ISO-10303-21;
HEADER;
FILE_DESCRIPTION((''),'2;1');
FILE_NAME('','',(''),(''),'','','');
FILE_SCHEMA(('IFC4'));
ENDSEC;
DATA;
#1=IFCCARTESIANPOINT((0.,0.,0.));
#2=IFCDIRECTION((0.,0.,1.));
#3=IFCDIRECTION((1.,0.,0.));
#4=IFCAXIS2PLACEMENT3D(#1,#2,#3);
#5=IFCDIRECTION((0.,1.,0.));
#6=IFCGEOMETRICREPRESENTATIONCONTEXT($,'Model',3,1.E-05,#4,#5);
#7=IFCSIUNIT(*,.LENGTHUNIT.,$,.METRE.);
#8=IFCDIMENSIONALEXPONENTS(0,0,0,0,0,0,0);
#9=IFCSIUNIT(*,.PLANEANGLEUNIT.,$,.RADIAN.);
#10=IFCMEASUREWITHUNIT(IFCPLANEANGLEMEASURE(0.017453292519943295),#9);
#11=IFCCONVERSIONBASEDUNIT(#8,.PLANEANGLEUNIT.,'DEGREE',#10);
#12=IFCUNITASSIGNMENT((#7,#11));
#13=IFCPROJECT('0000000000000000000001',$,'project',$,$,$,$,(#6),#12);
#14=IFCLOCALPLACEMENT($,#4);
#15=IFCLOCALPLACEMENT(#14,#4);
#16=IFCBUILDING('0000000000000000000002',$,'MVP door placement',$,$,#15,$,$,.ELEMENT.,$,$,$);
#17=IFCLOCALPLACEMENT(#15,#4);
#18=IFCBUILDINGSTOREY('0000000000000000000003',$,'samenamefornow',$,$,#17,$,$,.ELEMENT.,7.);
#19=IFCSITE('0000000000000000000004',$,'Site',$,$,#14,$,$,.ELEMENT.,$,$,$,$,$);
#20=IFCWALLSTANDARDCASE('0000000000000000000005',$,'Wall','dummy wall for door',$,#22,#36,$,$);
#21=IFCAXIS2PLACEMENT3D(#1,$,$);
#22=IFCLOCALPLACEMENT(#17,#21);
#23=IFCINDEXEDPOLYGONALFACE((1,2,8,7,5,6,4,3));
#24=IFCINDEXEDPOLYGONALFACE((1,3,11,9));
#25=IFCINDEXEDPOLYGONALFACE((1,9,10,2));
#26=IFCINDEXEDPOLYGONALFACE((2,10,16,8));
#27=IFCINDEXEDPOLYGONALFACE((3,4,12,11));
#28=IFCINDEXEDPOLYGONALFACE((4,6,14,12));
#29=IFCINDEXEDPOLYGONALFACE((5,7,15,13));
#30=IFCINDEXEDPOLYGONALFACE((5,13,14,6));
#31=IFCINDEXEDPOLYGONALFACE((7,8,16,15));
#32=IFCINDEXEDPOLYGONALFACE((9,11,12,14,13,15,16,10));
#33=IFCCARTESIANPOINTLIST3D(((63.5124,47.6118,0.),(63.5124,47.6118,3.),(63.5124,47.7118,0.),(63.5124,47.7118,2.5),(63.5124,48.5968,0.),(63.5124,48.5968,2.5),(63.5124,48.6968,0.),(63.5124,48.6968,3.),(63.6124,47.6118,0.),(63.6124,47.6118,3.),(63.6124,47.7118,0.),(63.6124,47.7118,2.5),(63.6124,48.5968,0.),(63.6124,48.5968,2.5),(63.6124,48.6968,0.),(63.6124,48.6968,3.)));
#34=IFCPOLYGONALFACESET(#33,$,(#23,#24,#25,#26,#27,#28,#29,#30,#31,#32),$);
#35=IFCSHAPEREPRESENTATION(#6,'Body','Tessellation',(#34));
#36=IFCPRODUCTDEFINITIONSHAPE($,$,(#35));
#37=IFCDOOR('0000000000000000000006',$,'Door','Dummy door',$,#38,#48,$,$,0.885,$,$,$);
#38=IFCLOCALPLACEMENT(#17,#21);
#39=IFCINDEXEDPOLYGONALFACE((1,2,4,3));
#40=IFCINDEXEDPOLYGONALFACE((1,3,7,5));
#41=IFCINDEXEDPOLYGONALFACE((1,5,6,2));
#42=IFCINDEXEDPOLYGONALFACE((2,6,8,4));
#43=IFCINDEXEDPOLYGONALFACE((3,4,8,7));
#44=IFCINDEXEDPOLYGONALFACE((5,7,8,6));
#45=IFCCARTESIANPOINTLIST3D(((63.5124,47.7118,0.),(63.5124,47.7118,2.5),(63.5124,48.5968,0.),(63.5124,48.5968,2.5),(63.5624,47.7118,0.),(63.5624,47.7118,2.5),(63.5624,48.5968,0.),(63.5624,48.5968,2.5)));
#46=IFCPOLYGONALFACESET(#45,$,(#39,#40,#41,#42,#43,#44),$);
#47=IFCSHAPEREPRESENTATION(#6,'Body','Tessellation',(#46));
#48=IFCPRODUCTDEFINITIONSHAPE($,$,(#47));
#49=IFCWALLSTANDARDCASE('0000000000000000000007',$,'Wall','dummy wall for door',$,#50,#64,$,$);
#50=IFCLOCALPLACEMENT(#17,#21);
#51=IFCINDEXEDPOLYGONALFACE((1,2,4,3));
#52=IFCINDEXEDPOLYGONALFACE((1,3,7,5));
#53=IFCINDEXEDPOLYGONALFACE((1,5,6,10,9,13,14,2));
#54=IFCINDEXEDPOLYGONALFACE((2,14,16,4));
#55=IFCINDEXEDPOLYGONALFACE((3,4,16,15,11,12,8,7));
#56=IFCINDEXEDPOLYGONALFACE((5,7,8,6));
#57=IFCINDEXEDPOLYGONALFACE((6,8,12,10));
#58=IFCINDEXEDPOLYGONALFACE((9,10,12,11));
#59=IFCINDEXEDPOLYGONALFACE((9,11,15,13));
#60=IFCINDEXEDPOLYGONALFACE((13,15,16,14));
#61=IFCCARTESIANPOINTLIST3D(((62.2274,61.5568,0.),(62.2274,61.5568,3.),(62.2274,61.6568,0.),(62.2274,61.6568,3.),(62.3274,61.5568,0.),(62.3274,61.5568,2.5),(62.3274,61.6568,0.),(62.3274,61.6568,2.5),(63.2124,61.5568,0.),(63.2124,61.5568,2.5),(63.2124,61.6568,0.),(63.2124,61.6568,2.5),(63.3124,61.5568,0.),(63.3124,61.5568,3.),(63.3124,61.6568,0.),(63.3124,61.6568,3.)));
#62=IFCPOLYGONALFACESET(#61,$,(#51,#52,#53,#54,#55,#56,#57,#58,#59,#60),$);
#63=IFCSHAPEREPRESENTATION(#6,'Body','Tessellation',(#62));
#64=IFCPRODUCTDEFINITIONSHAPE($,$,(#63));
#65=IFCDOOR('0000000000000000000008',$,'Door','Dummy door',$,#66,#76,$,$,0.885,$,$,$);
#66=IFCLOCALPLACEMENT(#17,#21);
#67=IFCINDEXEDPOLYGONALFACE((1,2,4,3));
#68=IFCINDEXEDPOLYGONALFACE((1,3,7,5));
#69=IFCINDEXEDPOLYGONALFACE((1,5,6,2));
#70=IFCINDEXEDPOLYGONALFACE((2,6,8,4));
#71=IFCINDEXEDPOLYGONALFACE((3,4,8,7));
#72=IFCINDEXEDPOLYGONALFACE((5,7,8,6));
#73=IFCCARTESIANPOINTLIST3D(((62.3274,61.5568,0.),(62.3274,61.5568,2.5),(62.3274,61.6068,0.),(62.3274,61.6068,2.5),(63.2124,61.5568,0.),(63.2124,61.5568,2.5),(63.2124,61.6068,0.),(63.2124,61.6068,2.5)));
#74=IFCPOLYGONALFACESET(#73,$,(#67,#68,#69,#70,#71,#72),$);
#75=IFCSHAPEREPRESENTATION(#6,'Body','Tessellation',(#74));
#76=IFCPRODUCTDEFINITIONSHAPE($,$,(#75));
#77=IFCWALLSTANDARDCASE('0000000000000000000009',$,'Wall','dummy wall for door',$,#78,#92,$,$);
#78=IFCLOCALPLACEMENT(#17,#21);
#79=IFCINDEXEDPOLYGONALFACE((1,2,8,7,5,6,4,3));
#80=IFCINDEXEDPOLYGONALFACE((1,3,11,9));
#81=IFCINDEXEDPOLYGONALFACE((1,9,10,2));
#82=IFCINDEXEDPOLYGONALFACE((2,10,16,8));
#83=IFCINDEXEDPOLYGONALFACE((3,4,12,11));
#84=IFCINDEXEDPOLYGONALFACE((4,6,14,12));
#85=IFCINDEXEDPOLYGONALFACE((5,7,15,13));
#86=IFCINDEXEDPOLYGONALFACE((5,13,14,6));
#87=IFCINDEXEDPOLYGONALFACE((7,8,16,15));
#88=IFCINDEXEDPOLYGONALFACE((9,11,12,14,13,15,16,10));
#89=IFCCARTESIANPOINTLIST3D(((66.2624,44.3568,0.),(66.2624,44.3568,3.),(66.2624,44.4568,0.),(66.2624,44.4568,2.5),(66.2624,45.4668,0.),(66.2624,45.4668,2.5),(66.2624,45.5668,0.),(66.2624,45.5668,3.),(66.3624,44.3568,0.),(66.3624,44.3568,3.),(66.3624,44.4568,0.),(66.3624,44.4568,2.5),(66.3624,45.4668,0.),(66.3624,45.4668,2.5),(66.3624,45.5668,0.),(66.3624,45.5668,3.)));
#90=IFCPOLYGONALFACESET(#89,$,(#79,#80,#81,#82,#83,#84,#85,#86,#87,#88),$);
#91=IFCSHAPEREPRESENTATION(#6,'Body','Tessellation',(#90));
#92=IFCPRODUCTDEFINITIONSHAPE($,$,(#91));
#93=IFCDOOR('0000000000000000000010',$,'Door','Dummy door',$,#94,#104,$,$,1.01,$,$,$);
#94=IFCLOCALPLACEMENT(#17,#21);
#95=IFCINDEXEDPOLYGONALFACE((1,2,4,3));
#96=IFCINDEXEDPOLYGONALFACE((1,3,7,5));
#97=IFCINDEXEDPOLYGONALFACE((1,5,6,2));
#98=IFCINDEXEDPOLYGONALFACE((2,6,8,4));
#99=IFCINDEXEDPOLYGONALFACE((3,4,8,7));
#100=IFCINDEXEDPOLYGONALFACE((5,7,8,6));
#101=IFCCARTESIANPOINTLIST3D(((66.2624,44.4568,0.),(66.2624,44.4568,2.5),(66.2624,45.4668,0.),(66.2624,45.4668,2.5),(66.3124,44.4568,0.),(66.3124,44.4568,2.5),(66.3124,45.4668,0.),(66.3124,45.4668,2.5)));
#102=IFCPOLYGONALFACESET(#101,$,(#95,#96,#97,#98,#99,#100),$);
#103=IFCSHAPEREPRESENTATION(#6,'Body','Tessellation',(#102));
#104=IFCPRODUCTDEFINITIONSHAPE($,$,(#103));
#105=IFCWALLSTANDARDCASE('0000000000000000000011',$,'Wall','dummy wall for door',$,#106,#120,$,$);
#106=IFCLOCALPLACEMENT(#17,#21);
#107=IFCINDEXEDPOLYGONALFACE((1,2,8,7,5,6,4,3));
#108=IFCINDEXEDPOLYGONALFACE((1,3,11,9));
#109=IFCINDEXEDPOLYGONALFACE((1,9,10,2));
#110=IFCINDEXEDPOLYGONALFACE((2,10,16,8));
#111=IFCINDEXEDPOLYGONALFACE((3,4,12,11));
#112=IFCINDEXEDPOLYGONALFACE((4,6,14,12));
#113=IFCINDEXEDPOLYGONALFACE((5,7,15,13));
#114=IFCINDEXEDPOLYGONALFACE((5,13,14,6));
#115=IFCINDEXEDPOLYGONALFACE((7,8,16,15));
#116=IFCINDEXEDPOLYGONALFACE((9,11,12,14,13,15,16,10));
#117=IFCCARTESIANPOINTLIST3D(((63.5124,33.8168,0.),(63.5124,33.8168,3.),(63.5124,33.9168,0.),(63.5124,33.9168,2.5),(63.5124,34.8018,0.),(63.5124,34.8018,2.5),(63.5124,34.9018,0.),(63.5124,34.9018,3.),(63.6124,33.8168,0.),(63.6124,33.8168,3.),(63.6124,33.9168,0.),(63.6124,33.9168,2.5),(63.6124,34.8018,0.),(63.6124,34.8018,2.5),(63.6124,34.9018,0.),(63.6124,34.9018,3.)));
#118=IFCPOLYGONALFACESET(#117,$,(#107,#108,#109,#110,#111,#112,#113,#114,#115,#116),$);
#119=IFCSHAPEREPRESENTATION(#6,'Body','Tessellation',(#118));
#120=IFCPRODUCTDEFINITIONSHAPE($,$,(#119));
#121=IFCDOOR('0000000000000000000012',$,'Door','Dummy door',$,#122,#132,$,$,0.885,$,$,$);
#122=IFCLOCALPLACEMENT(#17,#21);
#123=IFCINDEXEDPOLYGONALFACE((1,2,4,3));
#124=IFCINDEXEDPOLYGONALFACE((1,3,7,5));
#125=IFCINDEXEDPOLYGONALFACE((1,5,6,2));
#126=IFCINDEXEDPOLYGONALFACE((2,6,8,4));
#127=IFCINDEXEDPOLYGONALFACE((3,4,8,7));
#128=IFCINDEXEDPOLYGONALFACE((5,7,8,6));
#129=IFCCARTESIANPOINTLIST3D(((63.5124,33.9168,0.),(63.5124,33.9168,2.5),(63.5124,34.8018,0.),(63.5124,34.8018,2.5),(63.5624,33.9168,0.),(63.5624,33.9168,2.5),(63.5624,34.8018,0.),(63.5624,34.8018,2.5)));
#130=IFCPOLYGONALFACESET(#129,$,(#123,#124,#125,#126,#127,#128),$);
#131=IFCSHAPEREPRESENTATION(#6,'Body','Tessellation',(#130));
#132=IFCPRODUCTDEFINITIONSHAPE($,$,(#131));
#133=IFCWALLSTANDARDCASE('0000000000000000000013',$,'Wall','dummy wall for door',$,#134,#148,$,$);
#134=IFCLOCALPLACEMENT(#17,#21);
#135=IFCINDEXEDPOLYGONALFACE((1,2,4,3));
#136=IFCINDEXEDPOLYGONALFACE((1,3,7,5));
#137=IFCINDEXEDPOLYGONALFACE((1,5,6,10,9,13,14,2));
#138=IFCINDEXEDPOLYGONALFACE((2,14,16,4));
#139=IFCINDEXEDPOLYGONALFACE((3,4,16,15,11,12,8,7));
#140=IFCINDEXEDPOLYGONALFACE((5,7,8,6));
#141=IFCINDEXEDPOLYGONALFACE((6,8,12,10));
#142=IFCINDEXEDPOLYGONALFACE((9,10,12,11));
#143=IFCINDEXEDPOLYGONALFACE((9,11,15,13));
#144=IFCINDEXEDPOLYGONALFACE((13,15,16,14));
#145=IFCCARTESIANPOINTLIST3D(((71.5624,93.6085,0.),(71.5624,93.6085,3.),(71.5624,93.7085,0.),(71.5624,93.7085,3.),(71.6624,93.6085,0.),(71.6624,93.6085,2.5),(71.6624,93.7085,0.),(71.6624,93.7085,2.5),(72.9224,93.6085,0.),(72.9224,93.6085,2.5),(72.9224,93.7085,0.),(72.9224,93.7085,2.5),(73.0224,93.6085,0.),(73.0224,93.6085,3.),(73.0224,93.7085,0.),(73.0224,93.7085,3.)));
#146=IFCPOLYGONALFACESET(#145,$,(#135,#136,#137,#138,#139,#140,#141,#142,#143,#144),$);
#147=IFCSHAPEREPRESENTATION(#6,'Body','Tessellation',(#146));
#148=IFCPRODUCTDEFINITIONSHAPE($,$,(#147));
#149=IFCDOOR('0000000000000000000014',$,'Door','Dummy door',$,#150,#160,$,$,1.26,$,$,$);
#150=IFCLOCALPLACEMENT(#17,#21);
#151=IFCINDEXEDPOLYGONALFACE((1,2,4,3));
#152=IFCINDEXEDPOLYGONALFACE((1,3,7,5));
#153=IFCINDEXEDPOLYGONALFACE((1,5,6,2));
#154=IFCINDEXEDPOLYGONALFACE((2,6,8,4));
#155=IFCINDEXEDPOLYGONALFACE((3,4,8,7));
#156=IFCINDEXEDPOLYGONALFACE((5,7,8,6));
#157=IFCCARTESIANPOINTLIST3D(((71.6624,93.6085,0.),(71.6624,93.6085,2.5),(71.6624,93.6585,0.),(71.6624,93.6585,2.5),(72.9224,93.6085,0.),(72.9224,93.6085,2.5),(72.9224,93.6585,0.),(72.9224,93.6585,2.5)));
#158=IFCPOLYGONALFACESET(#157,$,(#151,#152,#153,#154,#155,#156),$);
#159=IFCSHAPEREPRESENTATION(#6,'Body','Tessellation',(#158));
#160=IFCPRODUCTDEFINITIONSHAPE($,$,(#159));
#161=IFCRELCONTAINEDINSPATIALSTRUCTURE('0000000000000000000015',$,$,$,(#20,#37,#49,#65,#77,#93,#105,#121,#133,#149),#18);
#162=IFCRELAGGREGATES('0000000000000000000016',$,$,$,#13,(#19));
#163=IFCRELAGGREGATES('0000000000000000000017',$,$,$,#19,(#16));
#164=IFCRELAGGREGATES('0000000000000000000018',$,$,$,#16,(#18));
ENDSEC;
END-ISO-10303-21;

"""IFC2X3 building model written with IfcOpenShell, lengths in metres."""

from ifc_helpers import new_model, entity, si_unit, converted_unit, direction, origin_with_axes, place, context, project, spatial, polyline, outline, extrude, element, fill, save


model = new_model("IFC2X3")

# Units and contexts
model_context = context("Model", 3, precision=1e-05, world=origin_with_axes(), true_north=direction((0.0, 1.0, 0.0)))
ifc_project = project(units=[si_unit("LENGTHUNIT", "METRE"), converted_unit("PLANEANGLEUNIT", "DEGREE", entity("IfcPlaneAngleMeasure", 0.017453292519943295), si_unit("PLANEANGLEUNIT", "RADIAN"), dimensions=[0, 0, 0, 0, 0, 0, 0])], contexts=[model_context])

# Site, building, storey
site_placement = place(None, origin_with_axes())
site = spatial("IfcSite", under=ifc_project, at=site_placement, Name="Site", CompositionType="ELEMENT")
building_placement = place(site_placement, origin_with_axes())
building = spatial("IfcBuilding", under=site, at=building_placement, Name="MVP door placement", CompositionType="ELEMENT")
storey_placement = place(building_placement, origin_with_axes())
storey = spatial("IfcBuildingStorey", under=building, at=storey_placement, Name="samenamefornow", CompositionType="ELEMENT", Elevation=7.0)

# Walls, openings, doors
wall_1_placement = place(storey_placement, origin_with_axes())
wall_1 = element("IfcWallStandardCase", 1, at=wall_1_placement, inside=storey, Name="Wall", Description="dummy wall for door", context=model_context, shape_type="SweptSolid", body=[
    extrude(outline(polyline([(63.5124, 47.6118, 0.0), (63.5124, 48.6968, 0.0), (63.6124, 48.6968, 0.0), (63.6124, 47.6118, 0.0), (63.5124, 47.6118, 0.0)])), origin_with_axes(), (0.0, 0.0, 1.0), 3.0),
])
opening_1_placement = place(wall_1_placement, origin_with_axes())
opening_1 = element("IfcOpeningElement", 2, at=opening_1_placement, cuts=wall_1, context=model_context, shape_type="SweptSolid", body=[
    extrude(outline(polyline([(63.5124, 47.7118, 0.0), (63.5124, 48.5968, 0.0), (63.6124, 48.5968, 0.0), (63.6124, 47.7118, 0.0), (63.5124, 47.7118, 0.0)])), origin_with_axes(), (0.0, 0.0, 1.0), 2.5),
])
door_1_placement = place(opening_1_placement, origin_with_axes())
door_1 = element("IfcDoor", 3, at=door_1_placement, inside=storey, Name="Door", Description="Dummy door", OverallWidth=0.885, context=model_context, shape_type="SweptSolid", body=[
    extrude(outline(polyline([(63.5124, 47.7118, 0.0), (63.5124, 48.5968, 0.0), (63.5624, 48.5968, 0.0), (63.5624, 47.7118, 0.0), (63.5124, 47.7118, 0.0)])), origin_with_axes(), (0.0, 0.0, 1.0), 2.5),
])
fill(opening_1, door_1)
wall_2_placement = place(storey_placement, origin_with_axes())
wall_2 = element("IfcWallStandardCase", 4, at=wall_2_placement, inside=storey, Name="Wall", Description="dummy wall for door", context=model_context, shape_type="SweptSolid", body=[
    extrude(outline(polyline([(62.2274, 61.5568, 0.0), (63.3124, 61.5568, 0.0), (63.3124, 61.6568, 0.0), (62.2274, 61.6568, 0.0), (62.2274, 61.5568, 0.0)])), origin_with_axes(), (0.0, 0.0, 1.0), 3.0),
])
opening_2_placement = place(wall_2_placement, origin_with_axes())
opening_2 = element("IfcOpeningElement", 5, at=opening_2_placement, cuts=wall_2, context=model_context, shape_type="SweptSolid", body=[
    extrude(outline(polyline([(62.3274, 61.5568, 0.0), (63.2124, 61.5568, 0.0), (63.2124, 61.6568, 0.0), (62.3274, 61.6568, 0.0), (62.3274, 61.5568, 0.0)])), origin_with_axes(), (0.0, 0.0, 1.0), 2.5),
])
door_2_placement = place(opening_2_placement, origin_with_axes())
door_2 = element("IfcDoor", 6, at=door_2_placement, inside=storey, Name="Door", Description="Dummy door", OverallWidth=0.885, context=model_context, shape_type="SweptSolid", body=[
    extrude(outline(polyline([(62.3274, 61.5568, 0.0), (63.2124, 61.5568, 0.0), (63.2124, 61.6068, 0.0), (62.3274, 61.6068, 0.0), (62.3274, 61.5568, 0.0)])), origin_with_axes(), (0.0, 0.0, 1.0), 2.5),
])
fill(opening_2, door_2)
wall_3_placement = place(storey_placement, origin_with_axes())
wall_3 = element("IfcWallStandardCase", 7, at=wall_3_placement, inside=storey, Name="Wall", Description="dummy wall for door", context=model_context, shape_type="SweptSolid", body=[
    extrude(outline(polyline([(66.2624, 45.5668, 0.0), (66.2624, 44.3568, 0.0), (66.3624, 44.3568, 0.0), (66.3624, 45.5668, 0.0), (66.2624, 45.5668, 0.0)])), origin_with_axes(), (0.0, 0.0, 1.0), 3.0),
])
opening_3_placement = place(wall_3_placement, origin_with_axes())
opening_3 = element("IfcOpeningElement", 8, at=opening_3_placement, cuts=wall_3, context=model_context, shape_type="SweptSolid", body=[
    extrude(outline(polyline([(66.2624, 45.4668, 0.0), (66.2624, 44.4568, 0.0), (66.3624, 44.4568, 0.0), (66.3624, 45.4668, 0.0), (66.2624, 45.4668, 0.0)])), origin_with_axes(), (0.0, 0.0, 1.0), 2.5),
])
door_3_placement = place(opening_3_placement, origin_with_axes())
door_3 = element("IfcDoor", 9, at=door_3_placement, inside=storey, Name="Door", Description="Dummy door", OverallWidth=1.01, context=model_context, shape_type="SweptSolid", body=[
    extrude(outline(polyline([(66.2624, 45.4668, 0.0), (66.2624, 44.4568, 0.0), (66.3124, 44.4568, 0.0), (66.3124, 45.4668, 0.0), (66.2624, 45.4668, 0.0)])), origin_with_axes(), (0.0, 0.0, 1.0), 2.5),
])
fill(opening_3, door_3)
wall_4_placement = place(storey_placement, origin_with_axes())
wall_4 = element("IfcWallStandardCase", 10, at=wall_4_placement, inside=storey, Name="Wall", Description="dummy wall for door", context=model_context, shape_type="SweptSolid", body=[
    extrude(outline(polyline([(63.5124, 34.9018, 0.0), (63.5124, 33.8168, 0.0), (63.6124, 33.8168, 0.0), (63.6124, 34.9018, 0.0), (63.5124, 34.9018, 0.0)])), origin_with_axes(), (0.0, 0.0, 1.0), 3.0),
])
opening_4_placement = place(wall_4_placement, origin_with_axes())
opening_4 = element("IfcOpeningElement", 11, at=opening_4_placement, cuts=wall_4, context=model_context, shape_type="SweptSolid", body=[
    extrude(outline(polyline([(63.5124, 34.8018, 0.0), (63.5124, 33.9168, 0.0), (63.6124, 33.9168, 0.0), (63.6124, 34.8018, 0.0), (63.5124, 34.8018, 0.0)])), origin_with_axes(), (0.0, 0.0, 1.0), 2.5),
])
door_4_placement = place(opening_4_placement, origin_with_axes())
door_4 = element("IfcDoor", 12, at=door_4_placement, inside=storey, Name="Door", Description="Dummy door", OverallWidth=0.885, context=model_context, shape_type="SweptSolid", body=[
    extrude(outline(polyline([(63.5124, 34.8018, 0.0), (63.5124, 33.9168, 0.0), (63.5624, 33.9168, 0.0), (63.5624, 34.8018, 0.0), (63.5124, 34.8018, 0.0)])), origin_with_axes(), (0.0, 0.0, 1.0), 2.5),
])
fill(opening_4, door_4)
wall_5_placement = place(storey_placement, origin_with_axes())
wall_5 = element("IfcWallStandardCase", 13, at=wall_5_placement, inside=storey, Name="Wall", Description="dummy wall for door", context=model_context, shape_type="SweptSolid", body=[
    extrude(outline(polyline([(73.0224, 93.6085, 0.0), (71.5624, 93.6085, 0.0), (71.5624, 93.7085, 0.0), (73.0224, 93.7085, 0.0), (73.0224, 93.6085, 0.0)])), origin_with_axes(), (0.0, 0.0, 1.0), 3.0),
])
opening_5_placement = place(wall_5_placement, origin_with_axes())
opening_5 = element("IfcOpeningElement", 14, at=opening_5_placement, cuts=wall_5, context=model_context, shape_type="SweptSolid", body=[
    extrude(outline(polyline([(72.9224, 93.6085, 0.0), (71.6624, 93.6085, 0.0), (71.6624, 93.7085, 0.0), (72.9224, 93.7085, 0.0), (72.9224, 93.6085, 0.0)])), origin_with_axes(), (0.0, 0.0, 1.0), 2.5),
])
door_5_placement = place(opening_5_placement, origin_with_axes())
door_5 = element("IfcDoor", 15, at=door_5_placement, inside=storey, Name="Door", Description="Dummy door", OverallWidth=1.26, context=model_context, shape_type="SweptSolid", body=[
    extrude(outline(polyline([(72.9224, 93.6085, 0.0), (71.6624, 93.6085, 0.0), (71.6624, 93.6585, 0.0), (72.9224, 93.6585, 0.0), (72.9224, 93.6085, 0.0)])), origin_with_axes(), (0.0, 0.0, 1.0), 2.5),
])
fill(opening_5, door_5)

save(model, "model.ifc")
